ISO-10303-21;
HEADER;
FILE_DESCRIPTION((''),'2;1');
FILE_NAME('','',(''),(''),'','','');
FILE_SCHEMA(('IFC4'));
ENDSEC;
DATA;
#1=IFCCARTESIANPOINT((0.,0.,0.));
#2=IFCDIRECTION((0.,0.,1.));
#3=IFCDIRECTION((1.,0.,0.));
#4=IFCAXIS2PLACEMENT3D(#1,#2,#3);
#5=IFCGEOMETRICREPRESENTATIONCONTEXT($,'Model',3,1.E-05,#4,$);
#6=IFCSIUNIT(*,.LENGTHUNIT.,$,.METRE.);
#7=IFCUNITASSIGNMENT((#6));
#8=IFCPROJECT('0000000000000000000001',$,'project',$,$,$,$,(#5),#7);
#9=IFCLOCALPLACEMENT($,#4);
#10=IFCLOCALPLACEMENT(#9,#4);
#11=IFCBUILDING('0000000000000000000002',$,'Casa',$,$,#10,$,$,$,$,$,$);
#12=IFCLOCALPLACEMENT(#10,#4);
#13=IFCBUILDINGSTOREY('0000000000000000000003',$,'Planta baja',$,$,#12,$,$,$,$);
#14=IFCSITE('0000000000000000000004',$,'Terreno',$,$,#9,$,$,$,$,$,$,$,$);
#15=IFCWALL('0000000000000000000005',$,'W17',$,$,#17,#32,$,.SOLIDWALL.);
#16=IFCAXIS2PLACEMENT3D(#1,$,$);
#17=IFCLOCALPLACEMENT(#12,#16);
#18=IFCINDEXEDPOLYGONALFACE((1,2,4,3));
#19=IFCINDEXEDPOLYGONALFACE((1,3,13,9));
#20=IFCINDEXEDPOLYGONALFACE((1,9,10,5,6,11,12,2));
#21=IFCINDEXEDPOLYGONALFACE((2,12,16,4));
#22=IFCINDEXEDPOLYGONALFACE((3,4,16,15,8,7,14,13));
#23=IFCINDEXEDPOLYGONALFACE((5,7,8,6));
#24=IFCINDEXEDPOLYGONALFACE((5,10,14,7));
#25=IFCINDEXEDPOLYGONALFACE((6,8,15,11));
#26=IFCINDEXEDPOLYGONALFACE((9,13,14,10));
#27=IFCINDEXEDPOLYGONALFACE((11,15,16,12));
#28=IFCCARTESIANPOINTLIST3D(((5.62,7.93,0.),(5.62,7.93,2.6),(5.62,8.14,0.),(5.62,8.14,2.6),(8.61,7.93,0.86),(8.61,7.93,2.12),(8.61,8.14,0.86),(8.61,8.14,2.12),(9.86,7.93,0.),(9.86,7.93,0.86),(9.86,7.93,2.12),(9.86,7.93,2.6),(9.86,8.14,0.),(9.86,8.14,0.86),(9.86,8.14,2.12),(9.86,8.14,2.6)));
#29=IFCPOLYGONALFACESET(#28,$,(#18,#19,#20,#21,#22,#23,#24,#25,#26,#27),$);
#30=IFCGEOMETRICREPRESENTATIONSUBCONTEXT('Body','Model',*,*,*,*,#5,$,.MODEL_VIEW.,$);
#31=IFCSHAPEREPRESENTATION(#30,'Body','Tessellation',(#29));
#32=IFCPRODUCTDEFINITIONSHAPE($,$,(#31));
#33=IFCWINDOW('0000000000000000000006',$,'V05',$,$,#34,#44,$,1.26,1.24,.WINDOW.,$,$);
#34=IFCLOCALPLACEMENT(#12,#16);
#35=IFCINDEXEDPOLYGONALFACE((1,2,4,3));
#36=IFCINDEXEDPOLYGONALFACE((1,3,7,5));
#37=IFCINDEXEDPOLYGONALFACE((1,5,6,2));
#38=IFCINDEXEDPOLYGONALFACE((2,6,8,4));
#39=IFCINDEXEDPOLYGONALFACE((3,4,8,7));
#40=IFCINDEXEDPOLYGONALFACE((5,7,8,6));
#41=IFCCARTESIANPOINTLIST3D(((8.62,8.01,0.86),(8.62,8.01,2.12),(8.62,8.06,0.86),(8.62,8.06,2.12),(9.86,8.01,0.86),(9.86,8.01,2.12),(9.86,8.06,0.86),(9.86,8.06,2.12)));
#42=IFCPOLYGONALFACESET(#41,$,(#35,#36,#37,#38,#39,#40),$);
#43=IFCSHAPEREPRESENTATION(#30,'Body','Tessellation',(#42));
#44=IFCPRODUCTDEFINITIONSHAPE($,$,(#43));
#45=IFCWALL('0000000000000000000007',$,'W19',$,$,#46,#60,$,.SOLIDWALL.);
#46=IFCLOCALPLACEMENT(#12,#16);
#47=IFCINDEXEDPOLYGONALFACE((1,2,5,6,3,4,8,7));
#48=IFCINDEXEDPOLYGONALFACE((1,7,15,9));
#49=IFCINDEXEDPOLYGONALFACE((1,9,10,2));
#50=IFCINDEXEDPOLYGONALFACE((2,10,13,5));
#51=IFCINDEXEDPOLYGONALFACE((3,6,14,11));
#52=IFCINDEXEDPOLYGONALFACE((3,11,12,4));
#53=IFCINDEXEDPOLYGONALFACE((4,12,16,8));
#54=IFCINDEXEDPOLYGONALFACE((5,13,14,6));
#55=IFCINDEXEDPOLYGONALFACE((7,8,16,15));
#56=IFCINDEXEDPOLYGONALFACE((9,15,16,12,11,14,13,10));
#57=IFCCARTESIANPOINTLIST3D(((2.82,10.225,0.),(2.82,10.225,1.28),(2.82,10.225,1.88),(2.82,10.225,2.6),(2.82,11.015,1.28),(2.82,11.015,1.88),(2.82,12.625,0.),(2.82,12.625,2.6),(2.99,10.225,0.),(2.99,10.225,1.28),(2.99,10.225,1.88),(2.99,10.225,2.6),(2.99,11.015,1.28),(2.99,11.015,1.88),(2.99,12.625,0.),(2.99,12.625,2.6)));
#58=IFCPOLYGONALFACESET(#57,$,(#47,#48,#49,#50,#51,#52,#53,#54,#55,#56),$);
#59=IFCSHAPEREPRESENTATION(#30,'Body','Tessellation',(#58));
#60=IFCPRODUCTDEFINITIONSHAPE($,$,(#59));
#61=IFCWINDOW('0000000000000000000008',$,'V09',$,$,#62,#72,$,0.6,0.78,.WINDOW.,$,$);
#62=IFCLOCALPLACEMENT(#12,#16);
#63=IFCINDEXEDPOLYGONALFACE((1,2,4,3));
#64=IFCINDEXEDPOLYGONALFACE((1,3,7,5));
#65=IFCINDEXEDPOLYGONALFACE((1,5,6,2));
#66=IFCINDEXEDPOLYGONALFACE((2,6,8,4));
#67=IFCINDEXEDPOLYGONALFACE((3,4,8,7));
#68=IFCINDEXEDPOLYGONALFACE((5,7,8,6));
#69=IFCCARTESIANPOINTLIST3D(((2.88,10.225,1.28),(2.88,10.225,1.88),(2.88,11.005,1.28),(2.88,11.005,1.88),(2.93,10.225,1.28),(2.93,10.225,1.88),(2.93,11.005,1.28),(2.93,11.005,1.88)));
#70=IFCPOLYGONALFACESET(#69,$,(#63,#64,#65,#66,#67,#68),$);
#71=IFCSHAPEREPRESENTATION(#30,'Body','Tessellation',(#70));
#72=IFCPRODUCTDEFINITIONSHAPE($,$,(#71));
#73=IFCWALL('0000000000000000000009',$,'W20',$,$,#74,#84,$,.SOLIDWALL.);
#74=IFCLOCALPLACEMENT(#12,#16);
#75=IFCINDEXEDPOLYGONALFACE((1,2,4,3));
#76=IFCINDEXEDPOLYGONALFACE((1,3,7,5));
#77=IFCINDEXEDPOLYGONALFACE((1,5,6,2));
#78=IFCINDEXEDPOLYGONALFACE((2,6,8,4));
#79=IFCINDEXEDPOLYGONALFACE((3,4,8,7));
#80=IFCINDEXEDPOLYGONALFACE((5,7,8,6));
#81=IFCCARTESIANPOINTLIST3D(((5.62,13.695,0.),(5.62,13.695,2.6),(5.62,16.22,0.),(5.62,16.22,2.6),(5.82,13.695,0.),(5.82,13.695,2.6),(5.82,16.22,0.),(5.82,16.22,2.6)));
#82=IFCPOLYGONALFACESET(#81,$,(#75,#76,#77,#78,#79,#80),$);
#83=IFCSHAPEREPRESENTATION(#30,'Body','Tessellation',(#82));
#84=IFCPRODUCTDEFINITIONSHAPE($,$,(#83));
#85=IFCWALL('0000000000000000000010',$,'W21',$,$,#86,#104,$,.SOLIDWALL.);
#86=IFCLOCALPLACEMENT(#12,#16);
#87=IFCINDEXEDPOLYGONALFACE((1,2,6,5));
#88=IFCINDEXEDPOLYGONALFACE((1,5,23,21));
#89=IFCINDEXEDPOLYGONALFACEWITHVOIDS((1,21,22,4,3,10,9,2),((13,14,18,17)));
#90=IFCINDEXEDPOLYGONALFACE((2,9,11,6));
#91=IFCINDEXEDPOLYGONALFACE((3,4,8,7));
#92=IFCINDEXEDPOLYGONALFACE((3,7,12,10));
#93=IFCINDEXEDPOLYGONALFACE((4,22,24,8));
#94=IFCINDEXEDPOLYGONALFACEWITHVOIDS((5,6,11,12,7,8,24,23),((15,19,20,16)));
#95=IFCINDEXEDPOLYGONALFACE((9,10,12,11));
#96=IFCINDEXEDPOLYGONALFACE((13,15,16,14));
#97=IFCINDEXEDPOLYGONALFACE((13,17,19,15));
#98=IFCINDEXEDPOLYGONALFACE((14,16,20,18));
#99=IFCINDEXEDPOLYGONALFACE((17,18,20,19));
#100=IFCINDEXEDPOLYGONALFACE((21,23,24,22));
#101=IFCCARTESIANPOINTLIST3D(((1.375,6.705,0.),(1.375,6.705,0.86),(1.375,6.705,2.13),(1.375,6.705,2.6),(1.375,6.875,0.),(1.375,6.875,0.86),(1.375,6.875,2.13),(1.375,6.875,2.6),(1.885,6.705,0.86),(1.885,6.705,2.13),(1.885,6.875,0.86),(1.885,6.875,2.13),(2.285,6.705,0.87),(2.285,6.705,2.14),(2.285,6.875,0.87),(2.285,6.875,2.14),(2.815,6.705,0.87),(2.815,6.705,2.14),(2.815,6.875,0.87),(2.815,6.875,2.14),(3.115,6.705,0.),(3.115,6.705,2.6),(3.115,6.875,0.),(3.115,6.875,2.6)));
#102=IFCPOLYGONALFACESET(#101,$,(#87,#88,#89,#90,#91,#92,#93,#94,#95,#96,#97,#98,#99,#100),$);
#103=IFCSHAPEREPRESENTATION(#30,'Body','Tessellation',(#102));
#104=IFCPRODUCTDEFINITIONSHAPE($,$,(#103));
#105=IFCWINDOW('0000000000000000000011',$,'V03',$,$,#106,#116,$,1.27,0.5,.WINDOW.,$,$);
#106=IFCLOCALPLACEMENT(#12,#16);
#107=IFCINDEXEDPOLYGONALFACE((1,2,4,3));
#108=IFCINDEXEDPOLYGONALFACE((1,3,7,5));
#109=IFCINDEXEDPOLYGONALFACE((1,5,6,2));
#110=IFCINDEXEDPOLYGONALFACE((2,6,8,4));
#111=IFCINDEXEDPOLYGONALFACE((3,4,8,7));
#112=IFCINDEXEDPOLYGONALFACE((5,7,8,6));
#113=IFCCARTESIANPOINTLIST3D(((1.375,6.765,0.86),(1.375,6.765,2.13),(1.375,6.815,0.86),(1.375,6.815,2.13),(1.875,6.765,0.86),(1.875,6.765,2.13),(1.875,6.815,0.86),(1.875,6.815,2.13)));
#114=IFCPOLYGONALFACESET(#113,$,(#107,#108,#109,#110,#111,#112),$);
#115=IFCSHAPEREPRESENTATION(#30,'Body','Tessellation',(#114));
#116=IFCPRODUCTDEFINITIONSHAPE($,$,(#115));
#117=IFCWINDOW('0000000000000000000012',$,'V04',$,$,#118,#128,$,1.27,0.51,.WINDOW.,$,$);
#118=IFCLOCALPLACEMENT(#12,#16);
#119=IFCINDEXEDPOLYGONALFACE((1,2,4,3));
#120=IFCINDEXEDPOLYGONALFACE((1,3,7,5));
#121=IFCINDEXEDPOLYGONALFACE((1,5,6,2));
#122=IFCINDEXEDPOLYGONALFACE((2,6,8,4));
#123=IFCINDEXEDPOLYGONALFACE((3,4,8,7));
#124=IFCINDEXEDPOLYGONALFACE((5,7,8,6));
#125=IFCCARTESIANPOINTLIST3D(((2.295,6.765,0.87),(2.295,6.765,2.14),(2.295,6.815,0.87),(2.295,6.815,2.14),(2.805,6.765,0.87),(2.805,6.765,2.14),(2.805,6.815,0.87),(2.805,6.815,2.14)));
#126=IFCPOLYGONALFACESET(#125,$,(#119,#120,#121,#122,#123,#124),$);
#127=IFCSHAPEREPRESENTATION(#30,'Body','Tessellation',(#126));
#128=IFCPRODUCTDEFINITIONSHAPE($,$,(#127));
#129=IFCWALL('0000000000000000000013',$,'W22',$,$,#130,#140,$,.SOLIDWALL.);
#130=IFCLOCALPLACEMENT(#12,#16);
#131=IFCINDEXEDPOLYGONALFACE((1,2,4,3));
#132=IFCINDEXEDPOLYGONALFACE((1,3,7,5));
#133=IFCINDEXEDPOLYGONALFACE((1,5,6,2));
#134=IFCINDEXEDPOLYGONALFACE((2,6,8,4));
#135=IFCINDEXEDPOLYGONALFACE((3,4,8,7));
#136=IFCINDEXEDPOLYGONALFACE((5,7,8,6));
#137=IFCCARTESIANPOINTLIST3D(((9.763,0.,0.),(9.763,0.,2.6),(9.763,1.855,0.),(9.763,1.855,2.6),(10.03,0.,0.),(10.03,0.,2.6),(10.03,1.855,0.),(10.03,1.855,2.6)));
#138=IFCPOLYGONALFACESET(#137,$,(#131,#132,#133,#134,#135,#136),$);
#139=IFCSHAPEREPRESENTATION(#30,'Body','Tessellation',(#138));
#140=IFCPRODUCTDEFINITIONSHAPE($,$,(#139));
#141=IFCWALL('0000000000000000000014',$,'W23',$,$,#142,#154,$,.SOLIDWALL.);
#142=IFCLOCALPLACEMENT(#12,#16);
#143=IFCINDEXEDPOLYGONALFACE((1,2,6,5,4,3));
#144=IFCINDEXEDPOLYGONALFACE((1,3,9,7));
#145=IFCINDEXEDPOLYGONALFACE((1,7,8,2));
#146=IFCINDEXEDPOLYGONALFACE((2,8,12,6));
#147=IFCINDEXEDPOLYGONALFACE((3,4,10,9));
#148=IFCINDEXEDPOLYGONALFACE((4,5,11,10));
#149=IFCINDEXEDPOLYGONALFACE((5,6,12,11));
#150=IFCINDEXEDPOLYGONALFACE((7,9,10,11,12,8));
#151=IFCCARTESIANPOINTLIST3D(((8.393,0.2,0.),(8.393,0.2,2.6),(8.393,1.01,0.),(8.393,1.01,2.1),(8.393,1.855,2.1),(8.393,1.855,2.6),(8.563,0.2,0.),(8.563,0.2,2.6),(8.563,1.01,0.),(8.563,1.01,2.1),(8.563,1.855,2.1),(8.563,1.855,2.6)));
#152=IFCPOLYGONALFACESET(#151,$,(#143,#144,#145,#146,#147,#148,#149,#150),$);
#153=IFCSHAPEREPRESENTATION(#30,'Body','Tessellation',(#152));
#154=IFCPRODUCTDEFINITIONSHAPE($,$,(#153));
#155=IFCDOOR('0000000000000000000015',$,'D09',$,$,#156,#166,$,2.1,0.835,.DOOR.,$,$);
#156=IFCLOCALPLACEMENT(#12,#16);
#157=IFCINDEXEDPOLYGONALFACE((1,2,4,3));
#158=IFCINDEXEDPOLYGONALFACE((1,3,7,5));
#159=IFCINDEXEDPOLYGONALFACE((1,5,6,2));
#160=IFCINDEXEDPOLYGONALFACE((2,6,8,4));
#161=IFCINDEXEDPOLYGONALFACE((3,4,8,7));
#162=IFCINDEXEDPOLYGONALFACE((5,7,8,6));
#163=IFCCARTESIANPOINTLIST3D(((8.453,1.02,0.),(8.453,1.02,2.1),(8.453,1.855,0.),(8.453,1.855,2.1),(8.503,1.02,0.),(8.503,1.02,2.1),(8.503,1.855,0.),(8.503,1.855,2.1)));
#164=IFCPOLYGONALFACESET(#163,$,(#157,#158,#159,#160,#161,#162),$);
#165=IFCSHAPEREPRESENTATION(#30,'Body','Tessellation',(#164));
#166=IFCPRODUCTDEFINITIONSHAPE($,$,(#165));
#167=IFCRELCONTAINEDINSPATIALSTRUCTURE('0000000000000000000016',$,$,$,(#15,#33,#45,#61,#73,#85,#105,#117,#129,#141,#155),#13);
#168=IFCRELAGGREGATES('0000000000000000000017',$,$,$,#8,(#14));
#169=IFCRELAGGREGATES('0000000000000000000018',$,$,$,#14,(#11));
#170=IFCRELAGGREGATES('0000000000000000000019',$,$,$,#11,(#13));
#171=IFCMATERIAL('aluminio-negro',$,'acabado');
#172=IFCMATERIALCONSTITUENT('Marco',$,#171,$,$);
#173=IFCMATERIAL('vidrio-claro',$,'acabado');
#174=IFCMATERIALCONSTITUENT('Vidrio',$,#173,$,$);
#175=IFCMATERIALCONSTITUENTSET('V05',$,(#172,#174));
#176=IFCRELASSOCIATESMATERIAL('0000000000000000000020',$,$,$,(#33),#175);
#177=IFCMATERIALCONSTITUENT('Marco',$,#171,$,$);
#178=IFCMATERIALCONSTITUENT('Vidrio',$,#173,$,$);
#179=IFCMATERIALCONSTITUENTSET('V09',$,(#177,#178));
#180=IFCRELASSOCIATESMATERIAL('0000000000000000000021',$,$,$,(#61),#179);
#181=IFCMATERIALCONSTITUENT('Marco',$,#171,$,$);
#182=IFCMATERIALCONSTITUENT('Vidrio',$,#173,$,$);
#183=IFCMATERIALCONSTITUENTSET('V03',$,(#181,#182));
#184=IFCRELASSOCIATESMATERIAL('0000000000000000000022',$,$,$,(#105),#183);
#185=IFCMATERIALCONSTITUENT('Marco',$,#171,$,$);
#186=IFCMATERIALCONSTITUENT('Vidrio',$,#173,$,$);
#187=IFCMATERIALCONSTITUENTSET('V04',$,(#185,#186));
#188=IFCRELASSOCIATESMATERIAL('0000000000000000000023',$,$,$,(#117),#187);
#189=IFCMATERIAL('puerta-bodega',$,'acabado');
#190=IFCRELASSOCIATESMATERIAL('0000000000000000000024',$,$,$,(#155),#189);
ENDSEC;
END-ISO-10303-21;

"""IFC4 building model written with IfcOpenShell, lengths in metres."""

from ifc_helpers import new_model, si_unit, frame, origin_with_axes, place, context, subcontext, project, spatial, line, indexed_curve, outline, extrude, material, constituent, constituent_set, element, fill, save


model = new_model("IFC4")

# Units and contexts
model_context = context("Model", 3, precision=1e-05, world=origin_with_axes())
body_context = subcontext(model_context, "Body", "Model", "MODEL_VIEW")
ifc_project = project(units=[si_unit("LENGTHUNIT", "METRE")], contexts=[model_context])

# Site, building, storey
site_placement = place(None, origin_with_axes())
site = spatial("IfcSite", under=ifc_project, at=site_placement, Name="Terreno")
building_placement = place(site_placement, origin_with_axes())
building = spatial("IfcBuilding", under=site, at=building_placement, Name="Casa")
storey_placement = place(building_placement, origin_with_axes())
storey = spatial("IfcBuildingStorey", under=building, at=storey_placement, Name="Planta baja")

# Walls, openings, windows
wall_1_placement = place(storey_placement, origin_with_axes())
wall_1 = element("IfcWall", 1, at=wall_1_placement, inside=storey, Name="W17", PredefinedType="SOLIDWALL", context=body_context, shape_type="SweptSolid", body=[
    extrude(outline(indexed_curve([(5.62, 7.93), (5.62, 8.14), (9.86, 8.14), (9.86, 7.93)], segments=[line(1, 2, 3, 4, 1)])), origin_with_axes(), (0.0, 0.0, 1.0), 2.6),
])
opening_1_placement = place(wall_1_placement, origin_with_axes())
opening_1 = element("IfcOpeningElement", 2, at=opening_1_placement, cuts=wall_1, PredefinedType="OPENING", context=body_context, shape_type="SweptSolid", body=[
    extrude(outline(indexed_curve([(8.61, 7.92), (9.87, 7.92), (9.87, 8.15), (8.61, 8.15)], segments=[line(1, 2, 3, 4, 1)])), frame((0.0, 0.0, 0.86), z_axis=(0.0, 0.0, 1.0), x_axis=(1.0, 0.0, 0.0)), (0.0, 0.0, 1.0), 1.26),
])
ifc_material_1 = material(Name="aluminio-negro", Category="acabado")
ifc_constituent_1 = constituent(ifc_material_1, Name="Marco")
ifc_material_2 = material(Name="vidrio-claro", Category="acabado")
ifc_constituent_2 = constituent(ifc_material_2, Name="Vidrio")
ifc_constituent_set_1 = constituent_set(constituents=[ifc_constituent_1, ifc_constituent_2], Name="V05")
window_1_placement = place(opening_1_placement, origin_with_axes())
window_1 = element("IfcWindow", 3, at=window_1_placement, inside=storey, material=ifc_constituent_set_1, Name="V05", OverallHeight=1.26, OverallWidth=1.24, PredefinedType="WINDOW", context=body_context, shape_type="SweptSolid", body=[
    extrude(outline(indexed_curve([(8.62, 8.01), (9.86, 8.01), (9.86, 8.06), (8.62, 8.06)], segments=[line(1, 2, 3, 4, 1)])), frame((0.0, 0.0, 0.86), z_axis=(0.0, 0.0, 1.0), x_axis=(1.0, 0.0, 0.0)), (0.0, 0.0, 1.0), 1.26),
])
fill(opening_1, window_1)
wall_2_placement = place(storey_placement, origin_with_axes())
wall_2 = element("IfcWall", 4, at=wall_2_placement, inside=storey, Name="W19", PredefinedType="SOLIDWALL", context=body_context, shape_type="SweptSolid", body=[
    extrude(outline(indexed_curve([(2.99, 10.225), (2.82, 10.225), (2.82, 12.625), (2.99, 12.625)], segments=[line(1, 2, 3, 4, 1)])), origin_with_axes(), (0.0, 0.0, 1.0), 2.6),
])
opening_2_placement = place(wall_2_placement, origin_with_axes())
opening_2 = element("IfcOpeningElement", 5, at=opening_2_placement, cuts=wall_2, PredefinedType="OPENING", context=body_context, shape_type="SweptSolid", body=[
    extrude(outline(indexed_curve([(2.81, 10.215), (2.81, 11.015), (3.0, 11.015), (3.0, 10.215)], segments=[line(1, 2, 3, 4, 1)])), frame((0.0, 0.0, 1.28), z_axis=(0.0, 0.0, 1.0), x_axis=(1.0, 0.0, 0.0)), (0.0, 0.0, 1.0), 0.6),
])
ifc_constituent_3 = constituent(ifc_material_1, Name="Marco")
ifc_constituent_4 = constituent(ifc_material_2, Name="Vidrio")
ifc_constituent_set_2 = constituent_set(constituents=[ifc_constituent_3, ifc_constituent_4], Name="V09")
window_2_placement = place(opening_2_placement, origin_with_axes())
window_2 = element("IfcWindow", 6, at=window_2_placement, inside=storey, material=ifc_constituent_set_2, Name="V09", OverallHeight=0.6, OverallWidth=0.78, PredefinedType="WINDOW", context=body_context, shape_type="SweptSolid", body=[
    extrude(outline(indexed_curve([(2.88, 10.225), (2.88, 11.005), (2.93, 11.005), (2.93, 10.225)], segments=[line(1, 2, 3, 4, 1)])), frame((0.0, 0.0, 1.28), z_axis=(0.0, 0.0, 1.0), x_axis=(1.0, 0.0, 0.0)), (0.0, 0.0, 1.0), 0.6),
])
fill(opening_2, window_2)

# Wall
wall_3_placement = place(storey_placement, origin_with_axes())
element("IfcWall", 7, at=wall_3_placement, inside=storey, Name="W20", PredefinedType="SOLIDWALL", context=body_context, shape_type="SweptSolid", body=[
    extrude(outline(indexed_curve([(5.62, 16.22), (5.82, 16.22), (5.82, 13.695), (5.62, 13.695)], segments=[line(1, 2, 3, 4, 1)])), origin_with_axes(), (0.0, 0.0, 1.0), 2.6),
])

# Wall, openings, windows
wall_4_placement = place(storey_placement, origin_with_axes())
wall_4 = element("IfcWall", 8, at=wall_4_placement, inside=storey, Name="W21", PredefinedType="SOLIDWALL", context=body_context, shape_type="SweptSolid", body=[
    extrude(outline(indexed_curve([(1.375, 6.705), (1.375, 6.875), (3.115, 6.875), (3.115, 6.705)], segments=[line(1, 2, 3, 4, 1)])), origin_with_axes(), (0.0, 0.0, 1.0), 2.6),
])
opening_3_placement = place(wall_4_placement, origin_with_axes())
opening_3 = element("IfcOpeningElement", 9, at=opening_3_placement, cuts=wall_4, PredefinedType="OPENING", context=body_context, shape_type="SweptSolid", body=[
    extrude(outline(indexed_curve([(1.365, 6.695), (1.885, 6.695), (1.885, 6.885), (1.365, 6.885)], segments=[line(1, 2, 3, 4, 1)])), frame((0.0, 0.0, 0.86), z_axis=(0.0, 0.0, 1.0), x_axis=(1.0, 0.0, 0.0)), (0.0, 0.0, 1.0), 1.27),
])
opening_4_placement = place(wall_4_placement, origin_with_axes())
opening_4 = element("IfcOpeningElement", 10, at=opening_4_placement, cuts=wall_4, PredefinedType="OPENING", context=body_context, shape_type="SweptSolid", body=[
    extrude(outline(indexed_curve([(2.285, 6.695), (2.815, 6.695), (2.815, 6.885), (2.285, 6.885)], segments=[line(1, 2, 3, 4, 1)])), frame((0.0, 0.0, 0.87), z_axis=(0.0, 0.0, 1.0), x_axis=(1.0, 0.0, 0.0)), (0.0, 0.0, 1.0), 1.27),
])
ifc_constituent_5 = constituent(ifc_material_1, Name="Marco")
ifc_constituent_6 = constituent(ifc_material_2, Name="Vidrio")
ifc_constituent_set_3 = constituent_set(constituents=[ifc_constituent_5, ifc_constituent_6], Name="V03")
window_3_placement = place(opening_3_placement, origin_with_axes())
window_3 = element("IfcWindow", 11, at=window_3_placement, inside=storey, material=ifc_constituent_set_3, Name="V03", OverallHeight=1.27, OverallWidth=0.5, PredefinedType="WINDOW", context=body_context, shape_type="SweptSolid", body=[
    extrude(outline(indexed_curve([(1.375, 6.765), (1.875, 6.765), (1.875, 6.815), (1.375, 6.815)], segments=[line(1, 2, 3, 4, 1)])), frame((0.0, 0.0, 0.86), z_axis=(0.0, 0.0, 1.0), x_axis=(1.0, 0.0, 0.0)), (0.0, 0.0, 1.0), 1.27),
])
fill(opening_3, window_3)
ifc_constituent_7 = constituent(ifc_material_1, Name="Marco")
ifc_constituent_8 = constituent(ifc_material_2, Name="Vidrio")
ifc_constituent_set_4 = constituent_set(constituents=[ifc_constituent_7, ifc_constituent_8], Name="V04")
window_4_placement = place(opening_4_placement, origin_with_axes())
window_4 = element("IfcWindow", 12, at=window_4_placement, inside=storey, material=ifc_constituent_set_4, Name="V04", OverallHeight=1.27, OverallWidth=0.51, PredefinedType="WINDOW", context=body_context, shape_type="SweptSolid", body=[
    extrude(outline(indexed_curve([(2.295, 6.765), (2.805, 6.765), (2.805, 6.815), (2.295, 6.815)], segments=[line(1, 2, 3, 4, 1)])), frame((0.0, 0.0, 0.87), z_axis=(0.0, 0.0, 1.0), x_axis=(1.0, 0.0, 0.0)), (0.0, 0.0, 1.0), 1.27),
])
fill(opening_4, window_4)

# Wall
wall_5_placement = place(storey_placement, origin_with_axes())
element("IfcWall", 13, at=wall_5_placement, inside=storey, Name="W22", PredefinedType="SOLIDWALL", context=body_context, shape_type="SweptSolid", body=[
    extrude(outline(indexed_curve([(9.763, 0.0), (9.763, 1.855), (10.03, 1.855), (10.03, 0.0)], segments=[line(1, 2, 3, 4, 1)])), origin_with_axes(), (0.0, 0.0, 1.0), 2.6),
])

# Wall, opening, door
wall_6_placement = place(storey_placement, origin_with_axes())
wall_6 = element("IfcWall", 14, at=wall_6_placement, inside=storey, Name="W23", PredefinedType="SOLIDWALL", context=body_context, shape_type="SweptSolid", body=[
    extrude(outline(indexed_curve([(8.393, 0.2), (8.393, 1.855), (8.563, 1.855), (8.563, 0.2)], segments=[line(1, 2, 3, 4, 1)])), origin_with_axes(), (0.0, 0.0, 1.0), 2.6),
])
opening_5_placement = place(wall_6_placement, origin_with_axes())
opening_5 = element("IfcOpeningElement", 15, at=opening_5_placement, cuts=wall_6, PredefinedType="OPENING", context=body_context, shape_type="SweptSolid", body=[
    extrude(outline(indexed_curve([(8.383, 1.01), (8.383, 1.865), (8.573, 1.865), (8.573, 1.01)], segments=[line(1, 2, 3, 4, 1)])), origin_with_axes(), (0.0, 0.0, 1.0), 2.1),
])
ifc_material_3 = material(Name="puerta-bodega", Category="acabado")
door_placement = place(opening_5_placement, origin_with_axes())
door = element("IfcDoor", 16, at=door_placement, inside=storey, material=ifc_material_3, Name="D09", OverallHeight=2.1, OverallWidth=0.835, PredefinedType="DOOR", context=body_context, shape_type="SweptSolid", body=[
    extrude(outline(indexed_curve([(8.453, 1.02), (8.453, 1.855), (8.503, 1.855), (8.503, 1.02)], segments=[line(1, 2, 3, 4, 1)])), origin_with_axes(), (0.0, 0.0, 1.0), 2.1),
])
fill(opening_5, door)

save(model, "model.ifc")
